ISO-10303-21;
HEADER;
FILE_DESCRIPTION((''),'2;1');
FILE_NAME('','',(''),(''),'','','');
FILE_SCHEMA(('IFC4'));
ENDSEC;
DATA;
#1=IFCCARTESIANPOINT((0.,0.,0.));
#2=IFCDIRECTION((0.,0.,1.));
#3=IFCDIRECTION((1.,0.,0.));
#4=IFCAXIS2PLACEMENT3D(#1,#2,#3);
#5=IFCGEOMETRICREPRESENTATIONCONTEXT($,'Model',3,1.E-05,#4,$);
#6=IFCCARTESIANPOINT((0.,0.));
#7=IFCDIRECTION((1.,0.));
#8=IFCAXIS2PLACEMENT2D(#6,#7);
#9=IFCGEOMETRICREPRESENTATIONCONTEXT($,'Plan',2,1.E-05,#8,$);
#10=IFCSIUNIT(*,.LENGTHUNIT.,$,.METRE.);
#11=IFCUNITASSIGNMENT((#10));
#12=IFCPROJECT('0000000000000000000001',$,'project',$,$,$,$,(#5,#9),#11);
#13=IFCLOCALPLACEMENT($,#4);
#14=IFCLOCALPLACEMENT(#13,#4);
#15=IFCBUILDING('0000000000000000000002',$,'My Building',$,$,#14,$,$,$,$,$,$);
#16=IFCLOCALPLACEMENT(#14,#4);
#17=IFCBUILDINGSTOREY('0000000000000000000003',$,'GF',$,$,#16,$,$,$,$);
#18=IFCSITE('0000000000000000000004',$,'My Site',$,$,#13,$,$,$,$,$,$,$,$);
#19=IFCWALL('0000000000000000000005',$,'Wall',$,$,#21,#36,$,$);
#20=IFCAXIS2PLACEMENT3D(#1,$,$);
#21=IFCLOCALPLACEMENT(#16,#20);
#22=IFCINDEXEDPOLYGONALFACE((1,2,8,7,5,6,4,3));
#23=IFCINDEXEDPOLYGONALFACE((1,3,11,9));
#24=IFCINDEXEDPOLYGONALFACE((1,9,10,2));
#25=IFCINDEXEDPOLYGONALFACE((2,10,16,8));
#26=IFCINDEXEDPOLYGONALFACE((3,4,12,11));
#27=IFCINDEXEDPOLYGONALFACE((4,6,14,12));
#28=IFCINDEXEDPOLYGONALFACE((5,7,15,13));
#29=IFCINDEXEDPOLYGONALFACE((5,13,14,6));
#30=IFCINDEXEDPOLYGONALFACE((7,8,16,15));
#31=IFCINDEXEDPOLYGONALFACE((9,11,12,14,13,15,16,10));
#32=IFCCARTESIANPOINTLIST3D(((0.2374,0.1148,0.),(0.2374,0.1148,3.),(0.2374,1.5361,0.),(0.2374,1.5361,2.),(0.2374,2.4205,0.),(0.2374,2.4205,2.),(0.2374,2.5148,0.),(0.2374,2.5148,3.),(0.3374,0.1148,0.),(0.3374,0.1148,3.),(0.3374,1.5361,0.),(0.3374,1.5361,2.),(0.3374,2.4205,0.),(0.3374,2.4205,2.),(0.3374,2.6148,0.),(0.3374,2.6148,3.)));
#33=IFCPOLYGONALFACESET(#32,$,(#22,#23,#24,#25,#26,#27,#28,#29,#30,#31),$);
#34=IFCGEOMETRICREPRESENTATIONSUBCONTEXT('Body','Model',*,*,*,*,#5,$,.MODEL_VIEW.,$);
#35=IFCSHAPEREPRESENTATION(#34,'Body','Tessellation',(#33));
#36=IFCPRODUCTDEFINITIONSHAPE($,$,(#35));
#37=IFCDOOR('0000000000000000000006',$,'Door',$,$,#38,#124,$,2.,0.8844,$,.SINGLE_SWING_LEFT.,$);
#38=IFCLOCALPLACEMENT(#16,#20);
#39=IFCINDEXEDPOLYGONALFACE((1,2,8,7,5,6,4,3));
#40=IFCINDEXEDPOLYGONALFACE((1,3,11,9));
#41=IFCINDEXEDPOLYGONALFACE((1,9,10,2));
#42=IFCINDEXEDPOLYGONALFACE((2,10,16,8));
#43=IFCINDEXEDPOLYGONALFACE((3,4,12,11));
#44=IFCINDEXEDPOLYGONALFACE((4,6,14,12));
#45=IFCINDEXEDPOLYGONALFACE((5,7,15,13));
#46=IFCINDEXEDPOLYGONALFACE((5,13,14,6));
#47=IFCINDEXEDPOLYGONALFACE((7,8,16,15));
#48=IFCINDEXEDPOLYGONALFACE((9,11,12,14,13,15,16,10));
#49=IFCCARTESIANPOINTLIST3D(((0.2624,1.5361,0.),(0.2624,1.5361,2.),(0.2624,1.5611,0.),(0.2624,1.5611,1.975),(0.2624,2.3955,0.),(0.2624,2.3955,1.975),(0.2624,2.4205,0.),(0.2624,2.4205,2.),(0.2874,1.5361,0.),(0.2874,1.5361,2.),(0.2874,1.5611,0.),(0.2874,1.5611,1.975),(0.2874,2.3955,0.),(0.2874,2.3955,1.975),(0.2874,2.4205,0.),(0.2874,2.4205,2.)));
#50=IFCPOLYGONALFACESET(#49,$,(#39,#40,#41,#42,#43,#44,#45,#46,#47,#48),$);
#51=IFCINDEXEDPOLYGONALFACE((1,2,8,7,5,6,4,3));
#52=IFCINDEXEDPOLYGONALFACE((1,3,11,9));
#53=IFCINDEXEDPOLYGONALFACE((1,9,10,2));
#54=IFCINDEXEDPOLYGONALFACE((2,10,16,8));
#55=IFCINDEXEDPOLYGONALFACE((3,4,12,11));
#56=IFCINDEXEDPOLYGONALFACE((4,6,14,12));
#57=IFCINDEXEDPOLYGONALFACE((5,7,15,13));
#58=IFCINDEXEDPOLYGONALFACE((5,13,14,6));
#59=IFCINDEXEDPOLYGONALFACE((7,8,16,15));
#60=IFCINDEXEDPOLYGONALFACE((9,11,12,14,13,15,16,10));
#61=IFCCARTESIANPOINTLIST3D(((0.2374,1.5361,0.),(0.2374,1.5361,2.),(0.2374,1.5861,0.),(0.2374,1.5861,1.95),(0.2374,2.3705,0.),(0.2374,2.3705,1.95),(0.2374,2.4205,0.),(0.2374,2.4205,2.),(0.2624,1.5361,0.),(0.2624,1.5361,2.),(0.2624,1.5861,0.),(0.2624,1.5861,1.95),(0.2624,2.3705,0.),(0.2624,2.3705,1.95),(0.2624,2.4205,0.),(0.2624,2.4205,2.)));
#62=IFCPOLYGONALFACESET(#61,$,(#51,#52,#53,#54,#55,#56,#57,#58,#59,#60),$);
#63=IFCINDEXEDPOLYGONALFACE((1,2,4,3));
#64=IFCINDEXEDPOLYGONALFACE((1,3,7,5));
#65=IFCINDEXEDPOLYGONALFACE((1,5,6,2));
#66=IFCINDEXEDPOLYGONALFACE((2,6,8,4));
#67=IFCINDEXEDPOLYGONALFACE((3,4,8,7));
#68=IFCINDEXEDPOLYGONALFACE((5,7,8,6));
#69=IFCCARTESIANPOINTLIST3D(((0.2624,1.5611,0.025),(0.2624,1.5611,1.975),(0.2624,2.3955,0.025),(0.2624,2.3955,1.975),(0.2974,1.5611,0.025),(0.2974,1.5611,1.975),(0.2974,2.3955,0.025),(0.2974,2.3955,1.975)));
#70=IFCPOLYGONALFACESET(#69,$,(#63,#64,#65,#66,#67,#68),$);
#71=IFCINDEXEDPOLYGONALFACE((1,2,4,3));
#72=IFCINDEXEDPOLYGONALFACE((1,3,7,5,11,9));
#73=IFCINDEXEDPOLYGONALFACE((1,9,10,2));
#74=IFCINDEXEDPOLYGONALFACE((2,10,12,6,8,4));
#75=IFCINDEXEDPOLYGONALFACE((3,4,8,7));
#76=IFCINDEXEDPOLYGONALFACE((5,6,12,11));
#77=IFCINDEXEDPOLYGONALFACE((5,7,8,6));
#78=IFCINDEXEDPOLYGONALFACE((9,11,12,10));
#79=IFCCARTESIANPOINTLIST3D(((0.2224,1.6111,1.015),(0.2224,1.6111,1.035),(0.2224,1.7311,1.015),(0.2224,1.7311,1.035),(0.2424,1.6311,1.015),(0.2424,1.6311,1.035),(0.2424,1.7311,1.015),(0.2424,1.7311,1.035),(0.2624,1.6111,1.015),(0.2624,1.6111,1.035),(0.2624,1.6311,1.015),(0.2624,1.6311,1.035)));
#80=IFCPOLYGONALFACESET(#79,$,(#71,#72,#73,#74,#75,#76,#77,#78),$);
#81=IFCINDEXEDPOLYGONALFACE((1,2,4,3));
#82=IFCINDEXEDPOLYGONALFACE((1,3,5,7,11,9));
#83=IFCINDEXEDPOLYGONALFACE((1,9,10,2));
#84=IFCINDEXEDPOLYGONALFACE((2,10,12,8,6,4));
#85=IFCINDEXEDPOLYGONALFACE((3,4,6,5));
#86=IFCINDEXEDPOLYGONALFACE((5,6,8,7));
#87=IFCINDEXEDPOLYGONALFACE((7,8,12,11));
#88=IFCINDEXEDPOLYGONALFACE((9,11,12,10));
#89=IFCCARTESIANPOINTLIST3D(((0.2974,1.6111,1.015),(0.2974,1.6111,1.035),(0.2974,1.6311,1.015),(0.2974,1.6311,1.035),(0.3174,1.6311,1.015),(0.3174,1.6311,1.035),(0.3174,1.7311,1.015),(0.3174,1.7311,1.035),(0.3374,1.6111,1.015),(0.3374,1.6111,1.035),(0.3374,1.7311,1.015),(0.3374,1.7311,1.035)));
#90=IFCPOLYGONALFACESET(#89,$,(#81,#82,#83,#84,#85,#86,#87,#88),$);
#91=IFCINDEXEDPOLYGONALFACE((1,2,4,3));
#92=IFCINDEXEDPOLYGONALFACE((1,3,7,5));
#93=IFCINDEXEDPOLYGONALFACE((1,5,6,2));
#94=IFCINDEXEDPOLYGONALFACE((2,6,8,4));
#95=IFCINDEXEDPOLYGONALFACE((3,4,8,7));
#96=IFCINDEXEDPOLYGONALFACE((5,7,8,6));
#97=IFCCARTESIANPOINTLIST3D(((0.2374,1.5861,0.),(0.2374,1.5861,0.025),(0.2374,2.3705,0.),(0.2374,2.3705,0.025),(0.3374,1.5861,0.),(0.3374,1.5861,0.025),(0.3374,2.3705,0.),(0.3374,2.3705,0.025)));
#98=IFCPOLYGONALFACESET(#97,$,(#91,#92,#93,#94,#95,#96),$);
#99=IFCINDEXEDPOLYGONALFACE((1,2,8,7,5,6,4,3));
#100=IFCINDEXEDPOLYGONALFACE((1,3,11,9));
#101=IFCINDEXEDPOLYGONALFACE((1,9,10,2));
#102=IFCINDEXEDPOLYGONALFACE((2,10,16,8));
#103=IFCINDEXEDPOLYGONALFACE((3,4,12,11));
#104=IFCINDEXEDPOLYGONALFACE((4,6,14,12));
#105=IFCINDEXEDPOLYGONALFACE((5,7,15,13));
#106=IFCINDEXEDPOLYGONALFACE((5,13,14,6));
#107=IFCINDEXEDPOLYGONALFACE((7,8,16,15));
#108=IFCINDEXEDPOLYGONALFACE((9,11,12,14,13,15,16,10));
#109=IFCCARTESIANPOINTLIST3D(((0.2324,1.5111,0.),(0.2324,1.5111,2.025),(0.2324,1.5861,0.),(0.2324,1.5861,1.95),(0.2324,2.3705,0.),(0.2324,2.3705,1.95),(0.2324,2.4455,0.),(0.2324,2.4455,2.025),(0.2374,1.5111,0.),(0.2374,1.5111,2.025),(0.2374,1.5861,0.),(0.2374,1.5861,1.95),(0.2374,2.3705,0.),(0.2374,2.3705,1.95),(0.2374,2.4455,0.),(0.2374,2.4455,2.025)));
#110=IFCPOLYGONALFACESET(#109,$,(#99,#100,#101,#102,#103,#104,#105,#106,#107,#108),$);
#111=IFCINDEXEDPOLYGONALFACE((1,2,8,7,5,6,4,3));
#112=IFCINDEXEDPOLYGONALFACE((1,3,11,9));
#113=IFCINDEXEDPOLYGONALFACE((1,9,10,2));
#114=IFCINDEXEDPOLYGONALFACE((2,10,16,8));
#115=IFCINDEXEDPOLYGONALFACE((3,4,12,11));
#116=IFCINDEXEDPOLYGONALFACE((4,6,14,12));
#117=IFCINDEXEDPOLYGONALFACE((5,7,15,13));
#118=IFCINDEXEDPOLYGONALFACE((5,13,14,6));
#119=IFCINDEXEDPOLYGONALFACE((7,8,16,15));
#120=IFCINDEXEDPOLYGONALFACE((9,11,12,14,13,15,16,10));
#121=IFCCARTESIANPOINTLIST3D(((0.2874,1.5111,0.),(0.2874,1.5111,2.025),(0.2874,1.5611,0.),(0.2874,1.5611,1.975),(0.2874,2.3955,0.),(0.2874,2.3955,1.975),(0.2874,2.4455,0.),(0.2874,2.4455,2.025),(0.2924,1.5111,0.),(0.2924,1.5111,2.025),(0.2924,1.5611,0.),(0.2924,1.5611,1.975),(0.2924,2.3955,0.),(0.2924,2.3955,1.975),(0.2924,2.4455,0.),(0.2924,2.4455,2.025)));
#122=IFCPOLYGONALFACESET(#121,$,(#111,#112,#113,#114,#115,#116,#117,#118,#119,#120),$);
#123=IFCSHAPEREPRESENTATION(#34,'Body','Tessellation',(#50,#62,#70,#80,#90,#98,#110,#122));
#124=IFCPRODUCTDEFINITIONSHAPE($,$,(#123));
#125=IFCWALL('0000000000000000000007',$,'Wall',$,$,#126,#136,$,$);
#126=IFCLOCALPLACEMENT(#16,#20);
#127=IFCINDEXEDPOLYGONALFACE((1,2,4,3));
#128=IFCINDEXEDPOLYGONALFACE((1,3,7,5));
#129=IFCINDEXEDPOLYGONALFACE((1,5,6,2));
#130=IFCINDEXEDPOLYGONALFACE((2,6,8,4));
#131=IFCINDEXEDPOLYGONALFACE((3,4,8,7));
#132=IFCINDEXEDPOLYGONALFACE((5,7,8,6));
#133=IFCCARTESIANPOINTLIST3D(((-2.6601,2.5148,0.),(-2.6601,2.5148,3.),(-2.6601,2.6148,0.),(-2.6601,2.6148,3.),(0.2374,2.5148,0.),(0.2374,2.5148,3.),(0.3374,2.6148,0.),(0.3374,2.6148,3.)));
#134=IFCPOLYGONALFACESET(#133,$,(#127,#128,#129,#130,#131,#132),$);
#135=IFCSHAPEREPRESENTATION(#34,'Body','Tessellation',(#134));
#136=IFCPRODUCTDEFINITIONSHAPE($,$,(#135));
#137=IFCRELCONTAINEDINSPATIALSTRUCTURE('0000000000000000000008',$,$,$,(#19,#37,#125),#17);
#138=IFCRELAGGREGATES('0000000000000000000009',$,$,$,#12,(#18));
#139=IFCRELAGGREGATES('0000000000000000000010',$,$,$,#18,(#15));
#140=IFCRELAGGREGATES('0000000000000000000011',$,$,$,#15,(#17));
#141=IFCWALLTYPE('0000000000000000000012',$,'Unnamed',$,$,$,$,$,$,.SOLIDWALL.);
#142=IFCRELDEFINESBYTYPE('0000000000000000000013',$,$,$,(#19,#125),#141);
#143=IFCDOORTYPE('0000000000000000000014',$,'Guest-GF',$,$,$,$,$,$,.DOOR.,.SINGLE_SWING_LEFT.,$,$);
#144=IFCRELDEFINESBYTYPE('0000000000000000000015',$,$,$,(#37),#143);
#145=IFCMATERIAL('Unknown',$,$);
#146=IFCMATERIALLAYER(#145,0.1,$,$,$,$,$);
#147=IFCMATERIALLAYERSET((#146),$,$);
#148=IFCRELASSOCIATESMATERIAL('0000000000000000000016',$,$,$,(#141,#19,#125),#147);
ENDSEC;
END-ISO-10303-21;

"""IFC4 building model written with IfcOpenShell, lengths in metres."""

from ifc_helpers import new_model, entity, si_unit, frame, origin_with_axes, origin_2d_with_axis, place, context, subcontext, project, spatial, line, indexed_curve, outline, extrude, shape, source, transform, mapped, material, layer, layer_set, layer_usage, type_object, type_shapes, element, fill, save


model = new_model("IFC4")

# Units and contexts
model_context = context("Model", 3, precision=1e-05, world=origin_with_axes())
plan_context = context("Plan", 2, precision=1e-05, world=origin_2d_with_axis())
body_context_1 = subcontext(model_context, "Body", "Model", "MODEL_VIEW")
body_context_2 = subcontext(plan_context, "Body", "Plan", "PLAN_VIEW")
ifc_project = project(units=[si_unit("LENGTHUNIT", "METRE")], contexts=[model_context, plan_context])

# Site, building, storey
site_placement = place(None, origin_with_axes())
site = spatial("IfcSite", under=ifc_project, at=site_placement, Name="My Site")
building_placement = place(site_placement, origin_with_axes())
building = spatial("IfcBuilding", under=site, at=building_placement, Name="My Building")
storey_placement = place(building_placement, origin_with_axes())
storey = spatial("IfcBuildingStorey", under=building, at=storey_placement, Name="GF")

# Shared definitions
ifc_material = material(Name="Unknown")

# Shared definitions
ifc_layer_1 = layer(ifc_material, 0.1)
ifc_layer_set_1 = layer_set([ifc_layer_1])
wall_type = type_object("IfcWallType", Name="Unnamed", PredefinedType="SOLIDWALL", material=ifc_layer_set_1)

# Wall, opening, door
ifc_layer_usage_1 = layer_usage(ifc_layer_set_1, "AXIS2", "POSITIVE", 0.0)
wall_1_placement = place(storey_placement, frame((0.3374, 0.1148, 0.0), z_axis=(0.0, 0.0, 1.0), x_axis=(0.0, 1.0, 0.0)))
wall_1 = element("IfcWall", 1, at=wall_1_placement, inside=storey, type_object=wall_type, material=ifc_layer_usage_1, Name="Wall", context=body_context_1, shape_type="SweptSolid", body=[
    extrude(outline(indexed_curve([(0.0, 0.0), (0.0, 0.1), (2.4, 0.1), (2.5, 0.0)], segments=[line(1, 2, 3, 4, 1)])), origin_with_axes(), (0.0, 0.0, 1.0), 3.0),
])
shared_shape_1 = source(origin_with_axes(), body_context_1, "Body", "SweptSolid", [
    extrude(outline(indexed_curve([(0.0, 0.0), (0.8844, 0.0), (0.8844, 2.0), (0.0, 2.0)], segments=[line(1, 2, 3, 4, 1)])), frame((0.0, -0.6, 0.0), z_axis=(0.0, -1.0, 0.0), x_axis=(1.0, 0.0, 0.0)), (0.0, 0.0, -1.0), 1.2),
])
opening_1_placement = place(wall_1_placement, frame((2.3057, 0.1, 0.0), z_axis=(0.0, 0.0, 1.0), x_axis=(-1.0, 0.0, 0.0)))
opening_1 = element("IfcOpeningElement", 2, at=opening_1_placement, cuts=wall_1, PredefinedType="OPENING", context=body_context_1, shape_type="MappedRepresentation", body=[
    mapped(shared_shape_1, transform((0.0, 0.0, 0.0), x_axis=(1.0, 0.0, 0.0), y_axis=(0.0, 1.0, 0.0), z_axis=(0.0, 0.0, 1.0), scale=1.0)),
])
door_type_1 = type_object("IfcDoorType", Name="Guest-GF", OperationType="SINGLE_SWING_LEFT", PredefinedType="DOOR")
shared_shape_2 = source(origin_with_axes(), body_context_1, "Body", "SweptSolid", [
    extrude(outline(indexed_curve([(0.0, 0.0), (0.0, 2.0), (0.8844, 2.0), (0.8844, 0.0), (0.8594, 0.0), (0.8594, 1.975), (0.025, 1.975), (0.025, 0.0)], segments=[line(1, 2, 3, 4, 5, 6, 7, 8, 1)])), frame((0.0, 0.025, 0.0), z_axis=(0.0, -1.0, 0.0), x_axis=(1.0, 0.0, 0.0)), (0.0, 0.0, -1.0), 0.025),
    extrude(outline(indexed_curve([(0.0, 0.0), (0.0, 2.0), (0.8844, 2.0), (0.8844, 0.0), (0.8344, 0.0), (0.8344, 1.95), (0.05, 1.95), (0.05, 0.0)], segments=[line(1, 2, 3, 4, 5, 6, 7, 8, 1)])), frame((0.0, 0.0, 0.0), z_axis=(0.0, -1.0, 0.0), x_axis=(1.0, 0.0, 0.0)), (0.0, 0.0, -1.0), 0.025),
    extrude(outline(indexed_curve([(0.0, 0.0), (0.8344, 0.0), (0.8344, 0.035), (0.0, 0.035)], segments=[line(1, 2, 3, 4, 1)])), frame((0.025, 0.025, 0.025), z_axis=(0.0, 0.0, 1.0), x_axis=(1.0, 0.0, 0.0)), (0.0, 0.0, 1.0), 1.95),
    extrude(outline(indexed_curve([(0.0, 0.0), (0.0, -0.04), (-0.12, -0.04), (-0.12, -0.02), (-0.02, -0.02), (-0.02, 0.0)], segments=[line(1, 2, 3, 4, 5, 6, 1)])), frame((0.8094, 0.025, 1.015), z_axis=(0.0, 0.0, 1.0), x_axis=(1.0, 0.0, 0.0)), (0.0, 0.0, 1.0), 0.02),
    extrude(outline(indexed_curve([(0.0, 0.0), (0.0, 0.04), (-0.12, 0.04), (-0.12, 0.02), (-0.02, 0.02), (-0.02, 0.0)], segments=[line(1, 2, 3, 4, 5, 6, 1)])), frame((0.8094, 0.06, 1.015), z_axis=(0.0, 0.0, 1.0), x_axis=(1.0, 0.0, 0.0)), (0.0, 0.0, 1.0), 0.02),
    extrude(outline(indexed_curve([(0.0, 0.0), (0.7844, 0.0), (0.7844, 0.1), (0.0, 0.1)], segments=[line(1, 2, 3, 4, 1)])), frame((0.05, 0.0, 0.0), z_axis=(0.0, 0.0, 1.0), x_axis=(1.0, 0.0, 0.0)), (0.0, 0.0, 1.0), 0.025),
    extrude(outline(indexed_curve([(0.0, 0.0), (0.0, 2.025), (0.9344, 2.025), (0.9344, 0.0), (0.8594, 0.0), (0.8594, 1.95), (0.075, 1.95), (0.075, 0.0)], segments=[line(1, 2, 3, 4, 5, 6, 7, 8, 1)])), frame((-0.025, -0.005, 0.0), z_axis=(0.0, -1.0, 0.0), x_axis=(1.0, 0.0, 0.0)), (0.0, 0.0, -1.0), 0.005),
    extrude(outline(indexed_curve([(0.0, 0.0), (0.0, 2.025), (0.9344, 2.025), (0.9344, 0.0), (0.8844, 0.0), (0.8844, 1.975), (0.05, 1.975), (0.05, 0.0)], segments=[line(1, 2, 3, 4, 5, 6, 7, 8, 1)])), frame((-0.025, 0.05, 0.0), z_axis=(0.0, -1.0, 0.0), x_axis=(1.0, 0.0, 0.0)), (0.0, 0.0, -1.0), 0.005),
])
shared_shape_3 = source(origin_with_axes(), body_context_2, "Body", "Curve2D", [
    entity("IfcIndexedPolyCurve", entity("IfcCartesianPointList2D", [[0.0, 0.0], [0.0, 0.05], [0.025, 0.05], [0.025, 0.025], [0.05, 0.025], [0.05, 0.0]]), [entity("IfcLineIndex", [1, 2, 3, 4, 5, 6, 1])]),
    entity("IfcIndexedPolyCurve", entity("IfcCartesianPointList2D", [[0.8844, 0.0], [0.8844, 0.05], [0.8594, 0.05], [0.8594, 0.025], [0.8344, 0.025], [0.8344, 0.0]]), [entity("IfcLineIndex", [1, 2, 3, 4, 5, 6, 1])]),
    entity("IfcTrimmedCurve", entity("IfcEllipse", entity("IfcAxis2Placement2D", entity("IfcCartesianPoint", [0.06, 0.05]), entity("IfcDirection", [1.0, 0.0])), 0.7994, 0.8344), [entity("IfcCartesianPoint", [0.8594, 0.05])], [entity("IfcCartesianPoint", [0.06, 0.8844])], True, "CARTESIAN"),
    entity("IfcIndexedPolyCurve", entity("IfcCartesianPointList2D", [[0.025, 0.05], [0.06, 0.05], [0.06, 0.8844], [0.025, 0.8844]]), [entity("IfcLineIndex", [1, 2, 3, 4, 1])]),
])
type_shapes(door_type_1, [shared_shape_2, shared_shape_3])
door_1_placement = place(opening_1_placement, frame((0.0, 0.0, 0.0), z_axis=(0.0, 0.0, 1.0), x_axis=(1.0, 0.0, 0.0)))
door_1 = element("IfcDoor", 3, at=door_1_placement, inside=storey, type_object=door_type_1, Name="Door", OperationType="SINGLE_SWING_LEFT", OverallHeight=2.0, OverallWidth=0.8844, shapes=[
    shape(body_context_1, "Body", "MappedRepresentation", [mapped(shared_shape_2, transform((0.0, 0.0, 0.0), x_axis=(1.0, 0.0, 0.0), y_axis=(0.0, 1.0, 0.0), z_axis=(0.0, 0.0, 1.0), scale=1.0))]),
    shape(body_context_2, "Body", "MappedRepresentation", [mapped(shared_shape_3, transform((0.0, 0.0, 0.0), x_axis=(1.0, 0.0, 0.0), y_axis=(0.0, 1.0, 0.0), z_axis=(0.0, 0.0, 1.0), scale=1.0))]),
])
fill(opening_1, door_1)

# Wall
ifc_layer_usage_2 = layer_usage(ifc_layer_set_1, "AXIS2", "POSITIVE", 0.0)
wall_2_placement = place(storey_placement, frame((0.3374, 2.6148, 0.0), z_axis=(0.0, 0.0, 1.0), x_axis=(-1.0, 0.0, 0.0)))
element("IfcWall", 4, at=wall_2_placement, inside=storey, type_object=wall_type, material=ifc_layer_usage_2, Name="Wall", context=body_context_1, shape_type="SweptSolid", body=[
    extrude(outline(indexed_curve([(0.0, 0.0), (0.1, 0.1), (2.9975, 0.1), (2.9975, 0.0)], segments=[line(1, 2, 3, 4, 1)])), origin_with_axes(), (0.0, 0.0, 1.0), 3.0),
])

save(model, "model.ifc")
